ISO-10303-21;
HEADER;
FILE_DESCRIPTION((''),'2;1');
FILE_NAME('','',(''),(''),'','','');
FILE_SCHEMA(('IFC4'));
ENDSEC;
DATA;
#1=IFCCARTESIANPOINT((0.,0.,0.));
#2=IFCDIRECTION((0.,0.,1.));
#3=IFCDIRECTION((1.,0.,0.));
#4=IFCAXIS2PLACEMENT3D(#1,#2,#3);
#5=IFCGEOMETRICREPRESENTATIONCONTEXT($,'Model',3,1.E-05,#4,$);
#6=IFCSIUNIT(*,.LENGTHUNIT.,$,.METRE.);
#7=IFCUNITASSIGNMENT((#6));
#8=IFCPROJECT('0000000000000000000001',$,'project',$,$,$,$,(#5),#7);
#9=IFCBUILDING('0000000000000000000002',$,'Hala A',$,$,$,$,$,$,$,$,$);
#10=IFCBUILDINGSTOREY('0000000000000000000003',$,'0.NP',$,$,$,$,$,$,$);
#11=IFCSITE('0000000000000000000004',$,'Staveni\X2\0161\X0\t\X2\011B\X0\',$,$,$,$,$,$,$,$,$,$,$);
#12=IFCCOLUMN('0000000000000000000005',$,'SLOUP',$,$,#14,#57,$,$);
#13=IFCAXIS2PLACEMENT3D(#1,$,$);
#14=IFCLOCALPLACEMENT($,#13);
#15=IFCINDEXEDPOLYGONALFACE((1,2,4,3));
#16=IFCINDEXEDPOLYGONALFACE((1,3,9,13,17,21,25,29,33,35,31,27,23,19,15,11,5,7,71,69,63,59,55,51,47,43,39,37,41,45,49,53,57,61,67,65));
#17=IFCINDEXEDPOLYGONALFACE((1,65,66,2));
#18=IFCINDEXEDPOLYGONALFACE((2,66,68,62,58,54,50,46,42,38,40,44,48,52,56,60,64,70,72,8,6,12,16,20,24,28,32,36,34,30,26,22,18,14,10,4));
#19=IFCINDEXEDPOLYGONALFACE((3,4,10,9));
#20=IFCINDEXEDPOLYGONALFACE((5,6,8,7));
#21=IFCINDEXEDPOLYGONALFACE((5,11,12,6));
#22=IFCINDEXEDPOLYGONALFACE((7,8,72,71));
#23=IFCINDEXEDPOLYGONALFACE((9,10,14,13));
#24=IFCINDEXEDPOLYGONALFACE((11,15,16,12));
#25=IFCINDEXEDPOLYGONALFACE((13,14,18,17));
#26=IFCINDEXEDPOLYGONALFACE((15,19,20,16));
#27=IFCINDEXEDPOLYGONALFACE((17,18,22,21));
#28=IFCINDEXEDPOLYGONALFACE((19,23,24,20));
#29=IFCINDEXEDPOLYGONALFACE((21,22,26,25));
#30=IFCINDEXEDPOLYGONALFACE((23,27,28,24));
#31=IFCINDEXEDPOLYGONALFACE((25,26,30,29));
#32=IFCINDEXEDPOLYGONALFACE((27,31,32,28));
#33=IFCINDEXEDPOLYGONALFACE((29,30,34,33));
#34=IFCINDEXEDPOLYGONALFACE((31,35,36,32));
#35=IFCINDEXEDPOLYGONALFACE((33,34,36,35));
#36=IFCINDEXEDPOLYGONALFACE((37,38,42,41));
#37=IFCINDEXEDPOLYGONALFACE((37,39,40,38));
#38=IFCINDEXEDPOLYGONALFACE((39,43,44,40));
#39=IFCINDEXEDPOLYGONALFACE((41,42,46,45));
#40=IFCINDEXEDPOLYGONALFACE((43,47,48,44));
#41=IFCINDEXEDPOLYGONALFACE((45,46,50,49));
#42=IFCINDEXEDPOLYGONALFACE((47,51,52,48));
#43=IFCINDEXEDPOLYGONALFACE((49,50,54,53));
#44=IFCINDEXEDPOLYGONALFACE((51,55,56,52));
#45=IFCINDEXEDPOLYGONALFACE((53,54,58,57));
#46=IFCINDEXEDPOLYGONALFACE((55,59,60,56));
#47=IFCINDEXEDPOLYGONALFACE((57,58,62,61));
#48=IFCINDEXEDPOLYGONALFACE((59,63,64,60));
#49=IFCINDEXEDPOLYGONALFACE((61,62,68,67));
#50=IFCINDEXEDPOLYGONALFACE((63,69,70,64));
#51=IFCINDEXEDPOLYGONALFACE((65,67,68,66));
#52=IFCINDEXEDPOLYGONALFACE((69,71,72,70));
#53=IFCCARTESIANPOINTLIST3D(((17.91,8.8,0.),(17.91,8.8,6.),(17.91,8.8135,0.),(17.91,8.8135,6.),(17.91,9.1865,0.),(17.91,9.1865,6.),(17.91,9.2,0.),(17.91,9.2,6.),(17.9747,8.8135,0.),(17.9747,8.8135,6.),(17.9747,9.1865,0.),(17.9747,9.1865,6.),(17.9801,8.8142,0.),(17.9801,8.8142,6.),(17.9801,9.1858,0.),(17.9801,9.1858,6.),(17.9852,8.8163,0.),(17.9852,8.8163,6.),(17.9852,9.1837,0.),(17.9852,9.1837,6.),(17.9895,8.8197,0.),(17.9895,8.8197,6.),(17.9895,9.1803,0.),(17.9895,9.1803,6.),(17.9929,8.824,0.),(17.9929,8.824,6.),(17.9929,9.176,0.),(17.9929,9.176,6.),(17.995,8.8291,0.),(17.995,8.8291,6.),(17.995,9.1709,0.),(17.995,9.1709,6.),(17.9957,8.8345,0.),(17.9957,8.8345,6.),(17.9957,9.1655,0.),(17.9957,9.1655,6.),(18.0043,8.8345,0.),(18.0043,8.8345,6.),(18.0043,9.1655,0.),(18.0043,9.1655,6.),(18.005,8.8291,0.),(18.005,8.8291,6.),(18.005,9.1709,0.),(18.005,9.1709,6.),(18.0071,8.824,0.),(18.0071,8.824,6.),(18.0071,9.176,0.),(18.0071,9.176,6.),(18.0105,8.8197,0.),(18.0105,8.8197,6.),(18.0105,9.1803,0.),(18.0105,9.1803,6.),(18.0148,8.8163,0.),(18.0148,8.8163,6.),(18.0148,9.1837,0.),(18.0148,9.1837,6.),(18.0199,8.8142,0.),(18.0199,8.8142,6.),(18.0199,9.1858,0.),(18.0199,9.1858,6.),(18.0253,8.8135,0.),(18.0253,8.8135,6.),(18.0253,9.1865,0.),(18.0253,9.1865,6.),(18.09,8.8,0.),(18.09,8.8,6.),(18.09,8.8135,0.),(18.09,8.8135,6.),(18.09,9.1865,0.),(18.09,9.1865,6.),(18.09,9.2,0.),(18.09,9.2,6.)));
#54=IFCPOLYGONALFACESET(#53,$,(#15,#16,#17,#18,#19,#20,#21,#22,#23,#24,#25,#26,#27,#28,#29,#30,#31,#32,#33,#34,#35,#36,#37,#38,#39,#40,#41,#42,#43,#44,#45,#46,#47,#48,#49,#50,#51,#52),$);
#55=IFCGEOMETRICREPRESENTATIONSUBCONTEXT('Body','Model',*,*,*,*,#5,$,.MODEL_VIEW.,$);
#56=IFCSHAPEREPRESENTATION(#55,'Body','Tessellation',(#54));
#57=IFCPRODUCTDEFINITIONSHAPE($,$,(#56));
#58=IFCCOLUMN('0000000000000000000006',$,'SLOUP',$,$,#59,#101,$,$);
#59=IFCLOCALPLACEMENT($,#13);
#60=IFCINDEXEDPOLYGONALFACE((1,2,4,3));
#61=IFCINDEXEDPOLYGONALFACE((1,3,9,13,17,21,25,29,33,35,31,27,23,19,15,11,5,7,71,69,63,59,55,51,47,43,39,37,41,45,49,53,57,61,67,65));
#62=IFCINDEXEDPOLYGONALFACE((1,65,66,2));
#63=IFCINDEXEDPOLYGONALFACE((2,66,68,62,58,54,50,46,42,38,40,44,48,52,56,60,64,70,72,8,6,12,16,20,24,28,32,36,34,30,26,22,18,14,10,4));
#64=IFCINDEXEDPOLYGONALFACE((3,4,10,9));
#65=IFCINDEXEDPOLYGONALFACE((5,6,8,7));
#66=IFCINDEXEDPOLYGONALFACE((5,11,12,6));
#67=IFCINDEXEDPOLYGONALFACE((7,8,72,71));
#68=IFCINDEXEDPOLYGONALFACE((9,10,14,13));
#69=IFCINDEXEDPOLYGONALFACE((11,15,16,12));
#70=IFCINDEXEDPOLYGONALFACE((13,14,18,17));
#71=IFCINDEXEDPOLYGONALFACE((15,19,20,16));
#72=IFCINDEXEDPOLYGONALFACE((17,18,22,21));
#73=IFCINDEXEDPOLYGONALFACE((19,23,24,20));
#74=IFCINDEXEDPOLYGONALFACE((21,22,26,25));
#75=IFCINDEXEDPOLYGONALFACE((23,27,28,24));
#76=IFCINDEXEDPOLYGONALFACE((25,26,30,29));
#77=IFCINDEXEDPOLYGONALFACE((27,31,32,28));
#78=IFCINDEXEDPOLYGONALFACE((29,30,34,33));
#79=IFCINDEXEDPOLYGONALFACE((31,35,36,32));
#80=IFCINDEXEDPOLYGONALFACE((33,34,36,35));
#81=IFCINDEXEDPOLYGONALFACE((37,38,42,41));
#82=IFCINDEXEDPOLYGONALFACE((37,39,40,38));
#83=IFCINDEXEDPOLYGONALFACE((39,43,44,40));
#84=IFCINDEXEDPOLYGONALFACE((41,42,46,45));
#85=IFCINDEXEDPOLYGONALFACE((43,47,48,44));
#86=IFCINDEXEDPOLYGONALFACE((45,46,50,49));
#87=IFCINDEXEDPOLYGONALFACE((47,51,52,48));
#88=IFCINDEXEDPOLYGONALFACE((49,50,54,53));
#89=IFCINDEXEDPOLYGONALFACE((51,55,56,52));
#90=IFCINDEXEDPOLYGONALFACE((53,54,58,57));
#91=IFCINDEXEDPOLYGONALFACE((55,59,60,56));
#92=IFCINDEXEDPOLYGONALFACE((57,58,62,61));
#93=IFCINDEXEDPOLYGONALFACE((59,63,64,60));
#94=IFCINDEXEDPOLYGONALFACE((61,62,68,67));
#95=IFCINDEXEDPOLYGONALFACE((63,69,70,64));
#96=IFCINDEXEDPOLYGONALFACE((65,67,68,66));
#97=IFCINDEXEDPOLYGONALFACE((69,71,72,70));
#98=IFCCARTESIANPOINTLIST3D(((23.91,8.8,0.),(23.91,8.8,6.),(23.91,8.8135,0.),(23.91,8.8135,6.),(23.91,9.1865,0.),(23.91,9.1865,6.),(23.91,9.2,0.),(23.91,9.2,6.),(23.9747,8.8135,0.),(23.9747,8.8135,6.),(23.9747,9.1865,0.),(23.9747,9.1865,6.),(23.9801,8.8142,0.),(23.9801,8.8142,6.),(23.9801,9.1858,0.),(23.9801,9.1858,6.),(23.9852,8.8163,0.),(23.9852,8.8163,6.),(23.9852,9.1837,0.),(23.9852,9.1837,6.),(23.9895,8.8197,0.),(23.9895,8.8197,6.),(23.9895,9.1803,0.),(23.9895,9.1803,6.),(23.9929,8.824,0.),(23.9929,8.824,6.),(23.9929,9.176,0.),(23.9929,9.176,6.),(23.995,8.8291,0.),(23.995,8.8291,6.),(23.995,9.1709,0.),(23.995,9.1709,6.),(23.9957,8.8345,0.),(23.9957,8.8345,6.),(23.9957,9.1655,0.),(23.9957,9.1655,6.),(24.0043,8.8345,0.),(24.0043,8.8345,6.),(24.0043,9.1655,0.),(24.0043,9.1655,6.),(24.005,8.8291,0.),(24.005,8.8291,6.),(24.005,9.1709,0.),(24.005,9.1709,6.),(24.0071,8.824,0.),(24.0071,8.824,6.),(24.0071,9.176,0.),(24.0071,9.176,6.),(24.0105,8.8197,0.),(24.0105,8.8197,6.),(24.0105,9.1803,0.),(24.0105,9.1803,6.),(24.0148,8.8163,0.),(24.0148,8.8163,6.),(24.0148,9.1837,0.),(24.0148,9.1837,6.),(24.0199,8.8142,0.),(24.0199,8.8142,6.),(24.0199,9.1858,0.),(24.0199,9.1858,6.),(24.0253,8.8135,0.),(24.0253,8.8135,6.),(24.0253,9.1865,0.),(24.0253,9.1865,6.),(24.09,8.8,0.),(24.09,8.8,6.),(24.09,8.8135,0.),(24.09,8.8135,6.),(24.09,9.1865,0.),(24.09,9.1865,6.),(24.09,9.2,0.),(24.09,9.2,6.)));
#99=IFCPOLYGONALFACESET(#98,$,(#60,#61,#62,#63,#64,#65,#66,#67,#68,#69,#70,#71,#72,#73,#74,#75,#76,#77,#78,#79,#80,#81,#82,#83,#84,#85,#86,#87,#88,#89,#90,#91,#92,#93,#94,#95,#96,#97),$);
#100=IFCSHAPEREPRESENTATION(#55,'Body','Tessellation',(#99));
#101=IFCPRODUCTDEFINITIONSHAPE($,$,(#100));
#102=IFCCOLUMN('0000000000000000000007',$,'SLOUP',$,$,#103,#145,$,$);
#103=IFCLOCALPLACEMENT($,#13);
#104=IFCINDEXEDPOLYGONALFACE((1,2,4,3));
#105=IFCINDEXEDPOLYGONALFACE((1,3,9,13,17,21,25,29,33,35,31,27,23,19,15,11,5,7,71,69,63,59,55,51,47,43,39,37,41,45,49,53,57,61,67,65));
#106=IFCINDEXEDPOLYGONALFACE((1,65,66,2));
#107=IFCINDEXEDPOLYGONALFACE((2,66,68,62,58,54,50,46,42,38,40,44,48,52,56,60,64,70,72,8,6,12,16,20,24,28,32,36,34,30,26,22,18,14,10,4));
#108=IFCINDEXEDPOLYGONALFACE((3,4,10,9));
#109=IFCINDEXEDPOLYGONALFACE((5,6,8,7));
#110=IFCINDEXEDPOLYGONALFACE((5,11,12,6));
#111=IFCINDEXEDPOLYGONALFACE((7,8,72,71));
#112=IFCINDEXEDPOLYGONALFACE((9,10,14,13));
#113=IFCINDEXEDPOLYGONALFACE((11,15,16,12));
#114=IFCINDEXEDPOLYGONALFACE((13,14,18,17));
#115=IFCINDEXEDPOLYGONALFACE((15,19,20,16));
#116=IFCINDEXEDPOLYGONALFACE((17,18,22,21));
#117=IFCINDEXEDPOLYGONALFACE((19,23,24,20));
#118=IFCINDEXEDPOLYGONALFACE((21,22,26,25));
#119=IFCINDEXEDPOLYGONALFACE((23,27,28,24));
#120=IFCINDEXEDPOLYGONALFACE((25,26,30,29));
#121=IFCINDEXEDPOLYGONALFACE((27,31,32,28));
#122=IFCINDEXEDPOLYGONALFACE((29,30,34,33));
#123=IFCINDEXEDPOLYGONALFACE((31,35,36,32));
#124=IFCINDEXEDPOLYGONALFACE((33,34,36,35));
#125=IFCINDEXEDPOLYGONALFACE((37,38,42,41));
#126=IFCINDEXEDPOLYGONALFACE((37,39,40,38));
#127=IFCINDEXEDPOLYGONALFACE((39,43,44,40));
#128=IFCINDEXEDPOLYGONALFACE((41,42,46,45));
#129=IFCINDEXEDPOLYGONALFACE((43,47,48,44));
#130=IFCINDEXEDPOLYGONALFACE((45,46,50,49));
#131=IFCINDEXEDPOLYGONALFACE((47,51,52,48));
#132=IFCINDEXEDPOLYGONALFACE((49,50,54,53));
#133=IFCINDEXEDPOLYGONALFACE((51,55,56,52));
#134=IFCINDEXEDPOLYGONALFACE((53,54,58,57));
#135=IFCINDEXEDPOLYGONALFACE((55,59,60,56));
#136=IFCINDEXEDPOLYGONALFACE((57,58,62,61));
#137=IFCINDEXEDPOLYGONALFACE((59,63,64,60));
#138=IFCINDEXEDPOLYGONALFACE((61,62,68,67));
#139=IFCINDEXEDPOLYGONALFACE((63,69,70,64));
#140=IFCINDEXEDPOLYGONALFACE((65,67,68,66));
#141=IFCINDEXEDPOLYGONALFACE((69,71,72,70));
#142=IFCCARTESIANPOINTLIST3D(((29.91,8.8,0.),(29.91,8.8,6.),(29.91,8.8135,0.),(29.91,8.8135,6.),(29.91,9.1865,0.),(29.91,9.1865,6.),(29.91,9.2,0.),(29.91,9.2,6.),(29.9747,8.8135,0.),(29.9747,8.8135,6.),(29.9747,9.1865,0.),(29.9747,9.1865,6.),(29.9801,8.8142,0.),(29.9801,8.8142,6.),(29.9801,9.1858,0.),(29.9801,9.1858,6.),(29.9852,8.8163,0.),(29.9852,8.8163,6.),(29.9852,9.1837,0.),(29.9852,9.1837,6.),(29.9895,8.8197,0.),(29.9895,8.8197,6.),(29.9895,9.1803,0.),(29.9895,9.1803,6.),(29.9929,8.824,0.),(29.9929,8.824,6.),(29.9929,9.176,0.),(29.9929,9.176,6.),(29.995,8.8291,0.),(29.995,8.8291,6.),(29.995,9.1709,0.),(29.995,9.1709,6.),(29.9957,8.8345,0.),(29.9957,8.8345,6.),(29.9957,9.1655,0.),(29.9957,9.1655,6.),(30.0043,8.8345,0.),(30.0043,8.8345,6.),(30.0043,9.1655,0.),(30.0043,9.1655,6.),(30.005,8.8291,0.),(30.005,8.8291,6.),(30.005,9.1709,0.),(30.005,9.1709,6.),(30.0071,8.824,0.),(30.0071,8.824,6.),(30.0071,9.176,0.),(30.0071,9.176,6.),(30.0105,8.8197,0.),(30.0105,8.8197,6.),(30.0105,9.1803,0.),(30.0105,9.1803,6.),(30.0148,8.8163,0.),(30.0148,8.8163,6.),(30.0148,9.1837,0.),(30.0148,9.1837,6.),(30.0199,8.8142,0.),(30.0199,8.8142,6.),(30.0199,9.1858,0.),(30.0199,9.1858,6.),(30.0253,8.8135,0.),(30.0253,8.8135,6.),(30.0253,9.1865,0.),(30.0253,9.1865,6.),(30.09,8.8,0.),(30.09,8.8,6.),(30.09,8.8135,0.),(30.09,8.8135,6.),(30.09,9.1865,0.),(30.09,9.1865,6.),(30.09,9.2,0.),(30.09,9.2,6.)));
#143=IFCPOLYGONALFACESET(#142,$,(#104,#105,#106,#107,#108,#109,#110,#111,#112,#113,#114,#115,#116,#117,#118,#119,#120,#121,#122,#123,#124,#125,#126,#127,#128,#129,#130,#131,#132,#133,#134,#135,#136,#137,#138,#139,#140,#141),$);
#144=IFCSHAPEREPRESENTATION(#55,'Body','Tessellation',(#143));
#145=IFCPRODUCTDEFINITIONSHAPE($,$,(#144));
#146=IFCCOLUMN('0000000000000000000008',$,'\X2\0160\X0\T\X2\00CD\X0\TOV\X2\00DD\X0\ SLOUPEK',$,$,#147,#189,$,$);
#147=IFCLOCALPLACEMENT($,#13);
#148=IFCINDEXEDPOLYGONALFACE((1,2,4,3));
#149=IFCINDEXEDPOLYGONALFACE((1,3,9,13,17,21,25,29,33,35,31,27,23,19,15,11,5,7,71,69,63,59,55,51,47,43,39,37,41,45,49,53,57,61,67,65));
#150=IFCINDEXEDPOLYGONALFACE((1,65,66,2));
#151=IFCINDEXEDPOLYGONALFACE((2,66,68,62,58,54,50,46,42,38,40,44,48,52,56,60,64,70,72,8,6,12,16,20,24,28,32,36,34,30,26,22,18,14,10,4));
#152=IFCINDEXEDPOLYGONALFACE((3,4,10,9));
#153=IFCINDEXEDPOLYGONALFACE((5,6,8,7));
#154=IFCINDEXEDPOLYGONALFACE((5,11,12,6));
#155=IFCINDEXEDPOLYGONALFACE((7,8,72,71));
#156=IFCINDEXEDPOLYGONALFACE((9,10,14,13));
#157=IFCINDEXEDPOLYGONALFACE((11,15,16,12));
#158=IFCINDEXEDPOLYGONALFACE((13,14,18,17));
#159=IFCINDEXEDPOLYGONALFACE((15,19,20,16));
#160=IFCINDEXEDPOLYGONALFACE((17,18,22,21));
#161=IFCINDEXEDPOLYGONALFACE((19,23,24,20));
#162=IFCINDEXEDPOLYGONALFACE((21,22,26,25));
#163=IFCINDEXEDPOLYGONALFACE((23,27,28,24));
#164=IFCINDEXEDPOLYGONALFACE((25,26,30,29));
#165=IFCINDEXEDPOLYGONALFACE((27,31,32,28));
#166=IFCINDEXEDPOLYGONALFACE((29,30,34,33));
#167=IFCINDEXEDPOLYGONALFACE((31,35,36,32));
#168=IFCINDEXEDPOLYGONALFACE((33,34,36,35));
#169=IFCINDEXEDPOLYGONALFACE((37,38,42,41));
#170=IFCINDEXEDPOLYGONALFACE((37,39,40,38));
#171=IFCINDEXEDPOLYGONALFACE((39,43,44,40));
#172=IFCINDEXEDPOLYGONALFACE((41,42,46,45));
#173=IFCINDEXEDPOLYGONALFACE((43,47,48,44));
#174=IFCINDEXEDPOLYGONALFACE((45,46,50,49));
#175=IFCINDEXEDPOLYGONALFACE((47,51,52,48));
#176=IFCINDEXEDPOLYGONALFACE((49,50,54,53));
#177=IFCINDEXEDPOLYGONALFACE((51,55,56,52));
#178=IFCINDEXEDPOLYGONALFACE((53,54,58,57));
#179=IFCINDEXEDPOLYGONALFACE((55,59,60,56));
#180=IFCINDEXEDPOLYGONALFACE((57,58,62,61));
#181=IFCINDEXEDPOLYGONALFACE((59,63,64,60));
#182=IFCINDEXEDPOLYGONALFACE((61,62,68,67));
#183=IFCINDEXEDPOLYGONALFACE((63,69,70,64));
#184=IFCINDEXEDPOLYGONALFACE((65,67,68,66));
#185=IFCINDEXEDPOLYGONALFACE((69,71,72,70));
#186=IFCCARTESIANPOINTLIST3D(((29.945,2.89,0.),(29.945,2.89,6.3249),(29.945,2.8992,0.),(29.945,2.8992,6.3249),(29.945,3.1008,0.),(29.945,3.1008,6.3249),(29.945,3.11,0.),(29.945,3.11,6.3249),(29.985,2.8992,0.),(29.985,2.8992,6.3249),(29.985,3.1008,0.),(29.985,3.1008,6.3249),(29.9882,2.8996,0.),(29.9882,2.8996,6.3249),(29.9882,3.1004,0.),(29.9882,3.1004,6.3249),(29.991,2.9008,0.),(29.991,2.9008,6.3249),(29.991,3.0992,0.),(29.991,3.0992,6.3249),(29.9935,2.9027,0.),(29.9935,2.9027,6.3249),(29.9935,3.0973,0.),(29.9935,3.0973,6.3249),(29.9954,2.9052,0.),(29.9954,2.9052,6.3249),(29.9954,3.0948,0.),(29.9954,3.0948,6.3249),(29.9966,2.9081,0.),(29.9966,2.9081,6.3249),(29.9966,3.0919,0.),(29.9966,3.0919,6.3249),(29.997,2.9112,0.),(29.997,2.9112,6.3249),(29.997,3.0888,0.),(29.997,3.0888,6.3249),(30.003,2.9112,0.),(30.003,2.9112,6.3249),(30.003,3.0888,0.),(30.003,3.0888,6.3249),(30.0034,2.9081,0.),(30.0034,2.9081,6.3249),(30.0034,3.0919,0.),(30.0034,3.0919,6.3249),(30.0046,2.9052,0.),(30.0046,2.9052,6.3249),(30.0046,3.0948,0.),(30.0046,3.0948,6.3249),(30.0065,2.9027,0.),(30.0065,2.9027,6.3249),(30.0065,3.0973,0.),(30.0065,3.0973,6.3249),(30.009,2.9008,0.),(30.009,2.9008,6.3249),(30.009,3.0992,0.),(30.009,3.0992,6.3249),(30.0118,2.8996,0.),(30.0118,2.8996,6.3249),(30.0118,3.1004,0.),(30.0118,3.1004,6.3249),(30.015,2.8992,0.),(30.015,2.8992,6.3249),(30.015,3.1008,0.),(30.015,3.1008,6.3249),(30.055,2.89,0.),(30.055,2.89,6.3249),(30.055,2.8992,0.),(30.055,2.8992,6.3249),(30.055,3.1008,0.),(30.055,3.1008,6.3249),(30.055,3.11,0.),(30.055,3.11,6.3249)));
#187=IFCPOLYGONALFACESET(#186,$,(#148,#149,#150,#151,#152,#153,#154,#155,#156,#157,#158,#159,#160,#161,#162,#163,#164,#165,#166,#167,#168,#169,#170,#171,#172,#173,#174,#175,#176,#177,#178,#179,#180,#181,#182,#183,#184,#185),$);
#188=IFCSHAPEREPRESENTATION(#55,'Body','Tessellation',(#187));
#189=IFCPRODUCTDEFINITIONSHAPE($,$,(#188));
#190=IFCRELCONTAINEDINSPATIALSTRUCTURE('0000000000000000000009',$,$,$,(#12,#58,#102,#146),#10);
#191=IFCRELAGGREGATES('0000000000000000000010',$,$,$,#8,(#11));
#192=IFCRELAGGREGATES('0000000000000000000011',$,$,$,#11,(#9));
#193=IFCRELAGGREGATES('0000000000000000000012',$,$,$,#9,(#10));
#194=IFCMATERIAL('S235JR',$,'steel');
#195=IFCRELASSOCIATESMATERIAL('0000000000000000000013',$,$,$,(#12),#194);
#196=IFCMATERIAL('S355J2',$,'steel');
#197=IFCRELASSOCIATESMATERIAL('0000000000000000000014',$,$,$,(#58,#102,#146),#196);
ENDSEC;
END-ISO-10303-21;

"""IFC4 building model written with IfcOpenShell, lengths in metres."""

from ifc_helpers import new_model, si_unit, frame, origin_with_axes, place, context, subcontext, project, spatial, i_section, extrude, material, element, save


model = new_model("IFC4")

# Units and contexts
model_context = context("Model", 3, precision=1e-05, world=origin_with_axes())
body_context = subcontext(model_context, "Body", "Model", "MODEL_VIEW")
ifc_project = project(units=[si_unit("LENGTHUNIT", "METRE")], contexts=[model_context])

# Site, building, storey
site = spatial("IfcSite", under=ifc_project, Name="Staveniště")
building = spatial("IfcBuilding", under=site, Name="Hala A")
storey = spatial("IfcBuildingStorey", under=building, Name="0.NP")

# Columns
ifc_material_1 = material(Name="S235JR", Category="steel")
column_1_placement = place(None, frame((18.0, 9.0, 0.0), z_axis=(0.0, 0.0, 1.0), x_axis=(1.0, 0.0, 0.0)))
element("IfcColumn", 1, at=column_1_placement, inside=storey, material=ifc_material_1, Name="SLOUP", context=body_context, shape_type="SweptSolid", body=[
    extrude(i_section(OverallWidth=0.18, OverallDepth=0.4, WebThickness=0.0086, FlangeThickness=0.0135, FilletRadius=0.021), origin_with_axes(), (0.0, 0.0, 1.0), 6.0),
])
ifc_material_2 = material(Name="S355J2", Category="steel")
for number, where, z_axis, x_axis, name in (
    (2, (24.0, 9.0, 0.0), (0.0, 0.0, 1.0), (1.0, 0.0, 0.0), "SLOUP"),
    (3, (30.0, 9.0, 0.0), (0.0, 0.0, 1.0), (1.0, 0.0, 0.0), "SLOUP"),
):
    element("IfcColumn", number, at=place(None, frame(where, z_axis=z_axis, x_axis=x_axis)), inside=storey, material=ifc_material_2, Name=name, context=body_context, shape_type="SweptSolid", body=[
        extrude(i_section(OverallWidth=0.18, OverallDepth=0.4, WebThickness=0.0086, FlangeThickness=0.0135, FilletRadius=0.021), origin_with_axes(), (0.0, 0.0, 1.0), 6.0),
    ])
column_2_placement = place(None, frame((30.0, 3.0, 0.0), z_axis=(0.0, 0.0, 1.0), x_axis=(1.0, 0.0, 0.0)))
element("IfcColumn", 4, at=column_2_placement, inside=storey, material=ifc_material_2, Name="ŠTÍTOVÝ SLOUPEK", context=body_context, shape_type="SweptSolid", body=[
    extrude(i_section(OverallWidth=0.11, OverallDepth=0.22, WebThickness=0.0059, FlangeThickness=0.0092, FilletRadius=0.012), origin_with_axes(), (0.0, 0.0, 1.0), 6.3249),
])

save(model, "model.ifc")
